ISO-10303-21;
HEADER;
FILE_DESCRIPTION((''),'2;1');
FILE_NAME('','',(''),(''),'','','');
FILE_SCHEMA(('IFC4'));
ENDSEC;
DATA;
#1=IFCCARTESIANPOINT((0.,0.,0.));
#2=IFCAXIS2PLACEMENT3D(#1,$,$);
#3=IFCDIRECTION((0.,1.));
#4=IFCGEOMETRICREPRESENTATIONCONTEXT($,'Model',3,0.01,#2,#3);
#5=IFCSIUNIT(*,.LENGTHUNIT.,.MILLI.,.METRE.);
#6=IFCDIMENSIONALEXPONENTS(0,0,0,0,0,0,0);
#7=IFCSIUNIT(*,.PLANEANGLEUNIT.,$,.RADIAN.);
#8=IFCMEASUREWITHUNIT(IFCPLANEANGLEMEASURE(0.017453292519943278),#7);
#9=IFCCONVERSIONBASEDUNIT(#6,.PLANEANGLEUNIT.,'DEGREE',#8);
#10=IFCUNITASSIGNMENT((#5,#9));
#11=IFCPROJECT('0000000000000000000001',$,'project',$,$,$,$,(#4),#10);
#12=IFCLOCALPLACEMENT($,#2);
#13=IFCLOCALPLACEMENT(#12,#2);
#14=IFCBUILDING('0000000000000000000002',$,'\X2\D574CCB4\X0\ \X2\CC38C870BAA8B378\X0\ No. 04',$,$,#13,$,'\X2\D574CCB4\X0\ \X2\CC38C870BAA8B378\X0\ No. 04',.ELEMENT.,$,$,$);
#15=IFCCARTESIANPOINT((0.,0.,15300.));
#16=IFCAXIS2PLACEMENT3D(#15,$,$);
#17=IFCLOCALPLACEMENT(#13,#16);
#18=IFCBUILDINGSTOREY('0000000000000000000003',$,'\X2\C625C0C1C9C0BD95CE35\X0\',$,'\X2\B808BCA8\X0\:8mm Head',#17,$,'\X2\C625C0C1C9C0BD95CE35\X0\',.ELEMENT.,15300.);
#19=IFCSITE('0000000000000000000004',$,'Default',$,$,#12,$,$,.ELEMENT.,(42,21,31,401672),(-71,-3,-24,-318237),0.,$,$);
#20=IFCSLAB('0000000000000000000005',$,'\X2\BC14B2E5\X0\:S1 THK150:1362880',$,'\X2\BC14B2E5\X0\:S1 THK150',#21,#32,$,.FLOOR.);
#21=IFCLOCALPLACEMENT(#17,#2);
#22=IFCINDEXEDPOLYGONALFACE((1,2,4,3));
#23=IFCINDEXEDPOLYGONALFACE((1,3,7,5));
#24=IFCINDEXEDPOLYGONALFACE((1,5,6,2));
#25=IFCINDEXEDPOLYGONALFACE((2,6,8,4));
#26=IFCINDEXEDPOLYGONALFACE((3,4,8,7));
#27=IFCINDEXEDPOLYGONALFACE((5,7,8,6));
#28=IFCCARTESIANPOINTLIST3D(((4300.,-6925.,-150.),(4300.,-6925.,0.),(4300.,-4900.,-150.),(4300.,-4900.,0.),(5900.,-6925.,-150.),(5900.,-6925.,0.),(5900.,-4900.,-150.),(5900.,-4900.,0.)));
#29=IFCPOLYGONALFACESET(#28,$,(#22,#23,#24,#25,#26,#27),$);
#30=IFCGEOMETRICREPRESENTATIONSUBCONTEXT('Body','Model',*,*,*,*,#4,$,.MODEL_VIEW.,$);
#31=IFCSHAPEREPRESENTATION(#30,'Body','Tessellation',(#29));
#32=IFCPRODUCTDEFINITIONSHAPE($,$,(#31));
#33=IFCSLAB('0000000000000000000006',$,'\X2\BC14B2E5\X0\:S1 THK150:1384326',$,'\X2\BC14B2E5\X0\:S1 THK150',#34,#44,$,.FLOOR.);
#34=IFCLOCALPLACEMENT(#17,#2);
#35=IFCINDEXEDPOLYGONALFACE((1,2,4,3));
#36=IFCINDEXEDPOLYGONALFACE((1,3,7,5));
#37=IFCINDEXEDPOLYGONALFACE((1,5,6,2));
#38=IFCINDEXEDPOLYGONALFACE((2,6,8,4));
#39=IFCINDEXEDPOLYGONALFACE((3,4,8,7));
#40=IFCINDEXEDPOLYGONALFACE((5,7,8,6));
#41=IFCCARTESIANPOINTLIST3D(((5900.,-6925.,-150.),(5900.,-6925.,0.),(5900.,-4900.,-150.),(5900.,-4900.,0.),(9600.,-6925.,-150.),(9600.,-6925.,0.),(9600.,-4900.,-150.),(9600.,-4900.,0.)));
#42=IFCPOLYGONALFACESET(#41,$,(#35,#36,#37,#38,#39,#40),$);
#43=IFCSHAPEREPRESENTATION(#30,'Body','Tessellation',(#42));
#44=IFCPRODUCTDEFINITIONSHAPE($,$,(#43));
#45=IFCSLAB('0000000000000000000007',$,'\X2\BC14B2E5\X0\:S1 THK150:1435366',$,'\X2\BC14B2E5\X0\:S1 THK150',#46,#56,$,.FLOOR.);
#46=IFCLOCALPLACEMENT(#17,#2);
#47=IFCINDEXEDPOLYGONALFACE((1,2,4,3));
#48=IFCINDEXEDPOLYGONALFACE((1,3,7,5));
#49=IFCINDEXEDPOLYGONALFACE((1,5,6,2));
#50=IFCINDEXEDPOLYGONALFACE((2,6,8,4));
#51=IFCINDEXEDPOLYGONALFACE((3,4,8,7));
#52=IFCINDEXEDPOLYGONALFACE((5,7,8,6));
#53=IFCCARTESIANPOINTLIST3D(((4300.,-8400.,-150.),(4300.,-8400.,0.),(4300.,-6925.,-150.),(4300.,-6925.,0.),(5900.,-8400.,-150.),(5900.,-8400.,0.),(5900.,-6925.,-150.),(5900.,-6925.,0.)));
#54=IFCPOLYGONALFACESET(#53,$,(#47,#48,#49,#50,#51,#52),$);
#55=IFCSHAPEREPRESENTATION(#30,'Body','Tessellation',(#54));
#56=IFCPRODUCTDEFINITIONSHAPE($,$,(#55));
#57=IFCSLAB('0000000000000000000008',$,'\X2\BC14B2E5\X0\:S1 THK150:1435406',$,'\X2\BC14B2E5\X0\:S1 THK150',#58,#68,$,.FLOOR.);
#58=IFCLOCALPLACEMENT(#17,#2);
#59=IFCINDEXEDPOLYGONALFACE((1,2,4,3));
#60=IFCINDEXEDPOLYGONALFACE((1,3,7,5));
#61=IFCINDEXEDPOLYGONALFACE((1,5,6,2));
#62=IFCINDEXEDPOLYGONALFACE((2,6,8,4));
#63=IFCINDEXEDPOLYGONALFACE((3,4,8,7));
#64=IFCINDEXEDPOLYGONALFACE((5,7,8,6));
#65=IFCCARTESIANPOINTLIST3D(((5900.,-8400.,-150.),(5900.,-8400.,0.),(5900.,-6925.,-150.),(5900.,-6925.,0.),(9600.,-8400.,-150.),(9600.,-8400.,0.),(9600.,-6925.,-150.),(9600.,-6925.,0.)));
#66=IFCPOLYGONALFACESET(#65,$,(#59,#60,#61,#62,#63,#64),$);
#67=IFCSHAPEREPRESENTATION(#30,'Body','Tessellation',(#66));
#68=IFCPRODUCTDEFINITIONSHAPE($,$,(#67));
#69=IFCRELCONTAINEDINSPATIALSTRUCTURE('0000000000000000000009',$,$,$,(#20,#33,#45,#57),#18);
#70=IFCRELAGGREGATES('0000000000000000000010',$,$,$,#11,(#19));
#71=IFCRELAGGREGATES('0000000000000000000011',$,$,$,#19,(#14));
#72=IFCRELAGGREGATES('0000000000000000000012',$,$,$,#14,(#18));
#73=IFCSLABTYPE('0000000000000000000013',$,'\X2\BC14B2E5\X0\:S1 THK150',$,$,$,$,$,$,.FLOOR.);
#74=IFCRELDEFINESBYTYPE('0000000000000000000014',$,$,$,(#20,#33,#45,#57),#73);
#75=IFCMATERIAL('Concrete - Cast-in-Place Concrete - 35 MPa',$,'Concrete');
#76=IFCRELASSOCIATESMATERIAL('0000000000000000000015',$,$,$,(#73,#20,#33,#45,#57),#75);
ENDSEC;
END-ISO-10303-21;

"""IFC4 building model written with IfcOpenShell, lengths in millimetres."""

from ifc_helpers import new_model, entity, si_unit, converted_unit, direction, frame, origin, place, context, subcontext, project, spatial, indexed_curve, outline, extrude, material, type_object, element, save


model = new_model("IFC4")

# Units and contexts
model_context = context("Model", 3, precision=0.01, world=origin(), true_north=direction((0.0, 1.0)))
body_context = subcontext(model_context, "Body", "Model", "MODEL_VIEW")
ifc_project = project(units=[si_unit("LENGTHUNIT", "METRE", prefix="MILLI"), converted_unit("PLANEANGLEUNIT", "DEGREE", entity("IfcPlaneAngleMeasure", 0.017453292519943278), si_unit("PLANEANGLEUNIT", "RADIAN"), dimensions=[0, 0, 0, 0, 0, 0, 0])], contexts=[model_context])

# Site, building, storey
site_placement = place(None, origin())
site = spatial("IfcSite", under=ifc_project, at=site_placement, Name="Default", CompositionType="ELEMENT", RefLatitude=(42, 21, 31, 401672), RefLongitude=(-71, -3, -24, -318237), RefElevation=0.0)
building_placement = place(site_placement, origin())
building = spatial("IfcBuilding", under=site, at=building_placement, Name="해체 참조모델 No. 04", LongName="해체 참조모델 No. 04", CompositionType="ELEMENT")
storey_placement = place(building_placement, frame((0.0, 0.0, 15300.0)))
storey = spatial("IfcBuildingStorey", under=building, at=storey_placement, Name="옥상지붕층", ObjectType="레벨:8mm Head", LongName="옥상지붕층", CompositionType="ELEMENT", Elevation=15300.0)

# Slabs
ifc_material = material(Name="Concrete - Cast-in-Place Concrete - 35 MPa", Category="Concrete")
slab_type = type_object("IfcSlabType", Name="바닥:S1 THK150", PredefinedType="FLOOR", material=ifc_material)
slab_1_placement = place(storey_placement, origin())
element("IfcSlab", 1, at=slab_1_placement, inside=storey, type_object=slab_type, material=ifc_material, Name="바닥:S1 THK150:1362880", ObjectType="바닥:S1 THK150", PredefinedType="FLOOR", context=body_context, shape_type="SweptSolid", body=[
    extrude(outline(indexed_curve([(-1012.5, -800.0), (1012.5, -800.0), (1012.5, 800.0), (-1012.5, 800.0), (-1012.5, -800.0)], self_intersect=False)), frame((5100.0, -5912.5, 0.0), z_axis=(0.0, 0.0, -1.0), x_axis=(0.0, 1.0, 0.0)), (0.0, 0.0, 1.0), 150.0),
])
slab_2_placement = place(storey_placement, origin())
element("IfcSlab", 2, at=slab_2_placement, inside=storey, type_object=slab_type, material=ifc_material, Name="바닥:S1 THK150:1384326", ObjectType="바닥:S1 THK150", PredefinedType="FLOOR", context=body_context, shape_type="SweptSolid", body=[
    extrude(outline(indexed_curve([(-1012.5, -1850.0), (1012.5, -1850.0), (1012.5, 1850.0), (-1012.5, 1850.0), (-1012.5, -1850.0)], self_intersect=False)), frame((7750.0, -5912.5, 0.0), z_axis=(0.0, 0.0, -1.0), x_axis=(0.0, 1.0, 0.0)), (0.0, 0.0, 1.0), 150.0),
])
slab_3_placement = place(storey_placement, origin())
element("IfcSlab", 3, at=slab_3_placement, inside=storey, type_object=slab_type, material=ifc_material, Name="바닥:S1 THK150:1435366", ObjectType="바닥:S1 THK150", PredefinedType="FLOOR", context=body_context, shape_type="SweptSolid", body=[
    extrude(outline(indexed_curve([(-737.5, -800.0), (737.5, -800.0), (737.5, 800.0), (-737.5, 800.0), (-737.5, -800.0)], self_intersect=False)), frame((5100.0, -7662.5, 0.0), z_axis=(0.0, 0.0, -1.0), x_axis=(0.0, 1.0, 0.0)), (0.0, 0.0, 1.0), 150.0),
])
slab_4_placement = place(storey_placement, origin())
element("IfcSlab", 4, at=slab_4_placement, inside=storey, type_object=slab_type, material=ifc_material, Name="바닥:S1 THK150:1435406", ObjectType="바닥:S1 THK150", PredefinedType="FLOOR", context=body_context, shape_type="SweptSolid", body=[
    extrude(outline(indexed_curve([(-737.5, -1850.0), (737.5, -1850.0), (737.5, 1850.0), (-737.5, 1850.0), (-737.5, -1850.0)], self_intersect=False)), frame((7750.0, -7662.5, 0.0), z_axis=(0.0, 0.0, -1.0), x_axis=(0.0, 1.0, 0.0)), (0.0, 0.0, 1.0), 150.0),
])

save(model, "model.ifc")
